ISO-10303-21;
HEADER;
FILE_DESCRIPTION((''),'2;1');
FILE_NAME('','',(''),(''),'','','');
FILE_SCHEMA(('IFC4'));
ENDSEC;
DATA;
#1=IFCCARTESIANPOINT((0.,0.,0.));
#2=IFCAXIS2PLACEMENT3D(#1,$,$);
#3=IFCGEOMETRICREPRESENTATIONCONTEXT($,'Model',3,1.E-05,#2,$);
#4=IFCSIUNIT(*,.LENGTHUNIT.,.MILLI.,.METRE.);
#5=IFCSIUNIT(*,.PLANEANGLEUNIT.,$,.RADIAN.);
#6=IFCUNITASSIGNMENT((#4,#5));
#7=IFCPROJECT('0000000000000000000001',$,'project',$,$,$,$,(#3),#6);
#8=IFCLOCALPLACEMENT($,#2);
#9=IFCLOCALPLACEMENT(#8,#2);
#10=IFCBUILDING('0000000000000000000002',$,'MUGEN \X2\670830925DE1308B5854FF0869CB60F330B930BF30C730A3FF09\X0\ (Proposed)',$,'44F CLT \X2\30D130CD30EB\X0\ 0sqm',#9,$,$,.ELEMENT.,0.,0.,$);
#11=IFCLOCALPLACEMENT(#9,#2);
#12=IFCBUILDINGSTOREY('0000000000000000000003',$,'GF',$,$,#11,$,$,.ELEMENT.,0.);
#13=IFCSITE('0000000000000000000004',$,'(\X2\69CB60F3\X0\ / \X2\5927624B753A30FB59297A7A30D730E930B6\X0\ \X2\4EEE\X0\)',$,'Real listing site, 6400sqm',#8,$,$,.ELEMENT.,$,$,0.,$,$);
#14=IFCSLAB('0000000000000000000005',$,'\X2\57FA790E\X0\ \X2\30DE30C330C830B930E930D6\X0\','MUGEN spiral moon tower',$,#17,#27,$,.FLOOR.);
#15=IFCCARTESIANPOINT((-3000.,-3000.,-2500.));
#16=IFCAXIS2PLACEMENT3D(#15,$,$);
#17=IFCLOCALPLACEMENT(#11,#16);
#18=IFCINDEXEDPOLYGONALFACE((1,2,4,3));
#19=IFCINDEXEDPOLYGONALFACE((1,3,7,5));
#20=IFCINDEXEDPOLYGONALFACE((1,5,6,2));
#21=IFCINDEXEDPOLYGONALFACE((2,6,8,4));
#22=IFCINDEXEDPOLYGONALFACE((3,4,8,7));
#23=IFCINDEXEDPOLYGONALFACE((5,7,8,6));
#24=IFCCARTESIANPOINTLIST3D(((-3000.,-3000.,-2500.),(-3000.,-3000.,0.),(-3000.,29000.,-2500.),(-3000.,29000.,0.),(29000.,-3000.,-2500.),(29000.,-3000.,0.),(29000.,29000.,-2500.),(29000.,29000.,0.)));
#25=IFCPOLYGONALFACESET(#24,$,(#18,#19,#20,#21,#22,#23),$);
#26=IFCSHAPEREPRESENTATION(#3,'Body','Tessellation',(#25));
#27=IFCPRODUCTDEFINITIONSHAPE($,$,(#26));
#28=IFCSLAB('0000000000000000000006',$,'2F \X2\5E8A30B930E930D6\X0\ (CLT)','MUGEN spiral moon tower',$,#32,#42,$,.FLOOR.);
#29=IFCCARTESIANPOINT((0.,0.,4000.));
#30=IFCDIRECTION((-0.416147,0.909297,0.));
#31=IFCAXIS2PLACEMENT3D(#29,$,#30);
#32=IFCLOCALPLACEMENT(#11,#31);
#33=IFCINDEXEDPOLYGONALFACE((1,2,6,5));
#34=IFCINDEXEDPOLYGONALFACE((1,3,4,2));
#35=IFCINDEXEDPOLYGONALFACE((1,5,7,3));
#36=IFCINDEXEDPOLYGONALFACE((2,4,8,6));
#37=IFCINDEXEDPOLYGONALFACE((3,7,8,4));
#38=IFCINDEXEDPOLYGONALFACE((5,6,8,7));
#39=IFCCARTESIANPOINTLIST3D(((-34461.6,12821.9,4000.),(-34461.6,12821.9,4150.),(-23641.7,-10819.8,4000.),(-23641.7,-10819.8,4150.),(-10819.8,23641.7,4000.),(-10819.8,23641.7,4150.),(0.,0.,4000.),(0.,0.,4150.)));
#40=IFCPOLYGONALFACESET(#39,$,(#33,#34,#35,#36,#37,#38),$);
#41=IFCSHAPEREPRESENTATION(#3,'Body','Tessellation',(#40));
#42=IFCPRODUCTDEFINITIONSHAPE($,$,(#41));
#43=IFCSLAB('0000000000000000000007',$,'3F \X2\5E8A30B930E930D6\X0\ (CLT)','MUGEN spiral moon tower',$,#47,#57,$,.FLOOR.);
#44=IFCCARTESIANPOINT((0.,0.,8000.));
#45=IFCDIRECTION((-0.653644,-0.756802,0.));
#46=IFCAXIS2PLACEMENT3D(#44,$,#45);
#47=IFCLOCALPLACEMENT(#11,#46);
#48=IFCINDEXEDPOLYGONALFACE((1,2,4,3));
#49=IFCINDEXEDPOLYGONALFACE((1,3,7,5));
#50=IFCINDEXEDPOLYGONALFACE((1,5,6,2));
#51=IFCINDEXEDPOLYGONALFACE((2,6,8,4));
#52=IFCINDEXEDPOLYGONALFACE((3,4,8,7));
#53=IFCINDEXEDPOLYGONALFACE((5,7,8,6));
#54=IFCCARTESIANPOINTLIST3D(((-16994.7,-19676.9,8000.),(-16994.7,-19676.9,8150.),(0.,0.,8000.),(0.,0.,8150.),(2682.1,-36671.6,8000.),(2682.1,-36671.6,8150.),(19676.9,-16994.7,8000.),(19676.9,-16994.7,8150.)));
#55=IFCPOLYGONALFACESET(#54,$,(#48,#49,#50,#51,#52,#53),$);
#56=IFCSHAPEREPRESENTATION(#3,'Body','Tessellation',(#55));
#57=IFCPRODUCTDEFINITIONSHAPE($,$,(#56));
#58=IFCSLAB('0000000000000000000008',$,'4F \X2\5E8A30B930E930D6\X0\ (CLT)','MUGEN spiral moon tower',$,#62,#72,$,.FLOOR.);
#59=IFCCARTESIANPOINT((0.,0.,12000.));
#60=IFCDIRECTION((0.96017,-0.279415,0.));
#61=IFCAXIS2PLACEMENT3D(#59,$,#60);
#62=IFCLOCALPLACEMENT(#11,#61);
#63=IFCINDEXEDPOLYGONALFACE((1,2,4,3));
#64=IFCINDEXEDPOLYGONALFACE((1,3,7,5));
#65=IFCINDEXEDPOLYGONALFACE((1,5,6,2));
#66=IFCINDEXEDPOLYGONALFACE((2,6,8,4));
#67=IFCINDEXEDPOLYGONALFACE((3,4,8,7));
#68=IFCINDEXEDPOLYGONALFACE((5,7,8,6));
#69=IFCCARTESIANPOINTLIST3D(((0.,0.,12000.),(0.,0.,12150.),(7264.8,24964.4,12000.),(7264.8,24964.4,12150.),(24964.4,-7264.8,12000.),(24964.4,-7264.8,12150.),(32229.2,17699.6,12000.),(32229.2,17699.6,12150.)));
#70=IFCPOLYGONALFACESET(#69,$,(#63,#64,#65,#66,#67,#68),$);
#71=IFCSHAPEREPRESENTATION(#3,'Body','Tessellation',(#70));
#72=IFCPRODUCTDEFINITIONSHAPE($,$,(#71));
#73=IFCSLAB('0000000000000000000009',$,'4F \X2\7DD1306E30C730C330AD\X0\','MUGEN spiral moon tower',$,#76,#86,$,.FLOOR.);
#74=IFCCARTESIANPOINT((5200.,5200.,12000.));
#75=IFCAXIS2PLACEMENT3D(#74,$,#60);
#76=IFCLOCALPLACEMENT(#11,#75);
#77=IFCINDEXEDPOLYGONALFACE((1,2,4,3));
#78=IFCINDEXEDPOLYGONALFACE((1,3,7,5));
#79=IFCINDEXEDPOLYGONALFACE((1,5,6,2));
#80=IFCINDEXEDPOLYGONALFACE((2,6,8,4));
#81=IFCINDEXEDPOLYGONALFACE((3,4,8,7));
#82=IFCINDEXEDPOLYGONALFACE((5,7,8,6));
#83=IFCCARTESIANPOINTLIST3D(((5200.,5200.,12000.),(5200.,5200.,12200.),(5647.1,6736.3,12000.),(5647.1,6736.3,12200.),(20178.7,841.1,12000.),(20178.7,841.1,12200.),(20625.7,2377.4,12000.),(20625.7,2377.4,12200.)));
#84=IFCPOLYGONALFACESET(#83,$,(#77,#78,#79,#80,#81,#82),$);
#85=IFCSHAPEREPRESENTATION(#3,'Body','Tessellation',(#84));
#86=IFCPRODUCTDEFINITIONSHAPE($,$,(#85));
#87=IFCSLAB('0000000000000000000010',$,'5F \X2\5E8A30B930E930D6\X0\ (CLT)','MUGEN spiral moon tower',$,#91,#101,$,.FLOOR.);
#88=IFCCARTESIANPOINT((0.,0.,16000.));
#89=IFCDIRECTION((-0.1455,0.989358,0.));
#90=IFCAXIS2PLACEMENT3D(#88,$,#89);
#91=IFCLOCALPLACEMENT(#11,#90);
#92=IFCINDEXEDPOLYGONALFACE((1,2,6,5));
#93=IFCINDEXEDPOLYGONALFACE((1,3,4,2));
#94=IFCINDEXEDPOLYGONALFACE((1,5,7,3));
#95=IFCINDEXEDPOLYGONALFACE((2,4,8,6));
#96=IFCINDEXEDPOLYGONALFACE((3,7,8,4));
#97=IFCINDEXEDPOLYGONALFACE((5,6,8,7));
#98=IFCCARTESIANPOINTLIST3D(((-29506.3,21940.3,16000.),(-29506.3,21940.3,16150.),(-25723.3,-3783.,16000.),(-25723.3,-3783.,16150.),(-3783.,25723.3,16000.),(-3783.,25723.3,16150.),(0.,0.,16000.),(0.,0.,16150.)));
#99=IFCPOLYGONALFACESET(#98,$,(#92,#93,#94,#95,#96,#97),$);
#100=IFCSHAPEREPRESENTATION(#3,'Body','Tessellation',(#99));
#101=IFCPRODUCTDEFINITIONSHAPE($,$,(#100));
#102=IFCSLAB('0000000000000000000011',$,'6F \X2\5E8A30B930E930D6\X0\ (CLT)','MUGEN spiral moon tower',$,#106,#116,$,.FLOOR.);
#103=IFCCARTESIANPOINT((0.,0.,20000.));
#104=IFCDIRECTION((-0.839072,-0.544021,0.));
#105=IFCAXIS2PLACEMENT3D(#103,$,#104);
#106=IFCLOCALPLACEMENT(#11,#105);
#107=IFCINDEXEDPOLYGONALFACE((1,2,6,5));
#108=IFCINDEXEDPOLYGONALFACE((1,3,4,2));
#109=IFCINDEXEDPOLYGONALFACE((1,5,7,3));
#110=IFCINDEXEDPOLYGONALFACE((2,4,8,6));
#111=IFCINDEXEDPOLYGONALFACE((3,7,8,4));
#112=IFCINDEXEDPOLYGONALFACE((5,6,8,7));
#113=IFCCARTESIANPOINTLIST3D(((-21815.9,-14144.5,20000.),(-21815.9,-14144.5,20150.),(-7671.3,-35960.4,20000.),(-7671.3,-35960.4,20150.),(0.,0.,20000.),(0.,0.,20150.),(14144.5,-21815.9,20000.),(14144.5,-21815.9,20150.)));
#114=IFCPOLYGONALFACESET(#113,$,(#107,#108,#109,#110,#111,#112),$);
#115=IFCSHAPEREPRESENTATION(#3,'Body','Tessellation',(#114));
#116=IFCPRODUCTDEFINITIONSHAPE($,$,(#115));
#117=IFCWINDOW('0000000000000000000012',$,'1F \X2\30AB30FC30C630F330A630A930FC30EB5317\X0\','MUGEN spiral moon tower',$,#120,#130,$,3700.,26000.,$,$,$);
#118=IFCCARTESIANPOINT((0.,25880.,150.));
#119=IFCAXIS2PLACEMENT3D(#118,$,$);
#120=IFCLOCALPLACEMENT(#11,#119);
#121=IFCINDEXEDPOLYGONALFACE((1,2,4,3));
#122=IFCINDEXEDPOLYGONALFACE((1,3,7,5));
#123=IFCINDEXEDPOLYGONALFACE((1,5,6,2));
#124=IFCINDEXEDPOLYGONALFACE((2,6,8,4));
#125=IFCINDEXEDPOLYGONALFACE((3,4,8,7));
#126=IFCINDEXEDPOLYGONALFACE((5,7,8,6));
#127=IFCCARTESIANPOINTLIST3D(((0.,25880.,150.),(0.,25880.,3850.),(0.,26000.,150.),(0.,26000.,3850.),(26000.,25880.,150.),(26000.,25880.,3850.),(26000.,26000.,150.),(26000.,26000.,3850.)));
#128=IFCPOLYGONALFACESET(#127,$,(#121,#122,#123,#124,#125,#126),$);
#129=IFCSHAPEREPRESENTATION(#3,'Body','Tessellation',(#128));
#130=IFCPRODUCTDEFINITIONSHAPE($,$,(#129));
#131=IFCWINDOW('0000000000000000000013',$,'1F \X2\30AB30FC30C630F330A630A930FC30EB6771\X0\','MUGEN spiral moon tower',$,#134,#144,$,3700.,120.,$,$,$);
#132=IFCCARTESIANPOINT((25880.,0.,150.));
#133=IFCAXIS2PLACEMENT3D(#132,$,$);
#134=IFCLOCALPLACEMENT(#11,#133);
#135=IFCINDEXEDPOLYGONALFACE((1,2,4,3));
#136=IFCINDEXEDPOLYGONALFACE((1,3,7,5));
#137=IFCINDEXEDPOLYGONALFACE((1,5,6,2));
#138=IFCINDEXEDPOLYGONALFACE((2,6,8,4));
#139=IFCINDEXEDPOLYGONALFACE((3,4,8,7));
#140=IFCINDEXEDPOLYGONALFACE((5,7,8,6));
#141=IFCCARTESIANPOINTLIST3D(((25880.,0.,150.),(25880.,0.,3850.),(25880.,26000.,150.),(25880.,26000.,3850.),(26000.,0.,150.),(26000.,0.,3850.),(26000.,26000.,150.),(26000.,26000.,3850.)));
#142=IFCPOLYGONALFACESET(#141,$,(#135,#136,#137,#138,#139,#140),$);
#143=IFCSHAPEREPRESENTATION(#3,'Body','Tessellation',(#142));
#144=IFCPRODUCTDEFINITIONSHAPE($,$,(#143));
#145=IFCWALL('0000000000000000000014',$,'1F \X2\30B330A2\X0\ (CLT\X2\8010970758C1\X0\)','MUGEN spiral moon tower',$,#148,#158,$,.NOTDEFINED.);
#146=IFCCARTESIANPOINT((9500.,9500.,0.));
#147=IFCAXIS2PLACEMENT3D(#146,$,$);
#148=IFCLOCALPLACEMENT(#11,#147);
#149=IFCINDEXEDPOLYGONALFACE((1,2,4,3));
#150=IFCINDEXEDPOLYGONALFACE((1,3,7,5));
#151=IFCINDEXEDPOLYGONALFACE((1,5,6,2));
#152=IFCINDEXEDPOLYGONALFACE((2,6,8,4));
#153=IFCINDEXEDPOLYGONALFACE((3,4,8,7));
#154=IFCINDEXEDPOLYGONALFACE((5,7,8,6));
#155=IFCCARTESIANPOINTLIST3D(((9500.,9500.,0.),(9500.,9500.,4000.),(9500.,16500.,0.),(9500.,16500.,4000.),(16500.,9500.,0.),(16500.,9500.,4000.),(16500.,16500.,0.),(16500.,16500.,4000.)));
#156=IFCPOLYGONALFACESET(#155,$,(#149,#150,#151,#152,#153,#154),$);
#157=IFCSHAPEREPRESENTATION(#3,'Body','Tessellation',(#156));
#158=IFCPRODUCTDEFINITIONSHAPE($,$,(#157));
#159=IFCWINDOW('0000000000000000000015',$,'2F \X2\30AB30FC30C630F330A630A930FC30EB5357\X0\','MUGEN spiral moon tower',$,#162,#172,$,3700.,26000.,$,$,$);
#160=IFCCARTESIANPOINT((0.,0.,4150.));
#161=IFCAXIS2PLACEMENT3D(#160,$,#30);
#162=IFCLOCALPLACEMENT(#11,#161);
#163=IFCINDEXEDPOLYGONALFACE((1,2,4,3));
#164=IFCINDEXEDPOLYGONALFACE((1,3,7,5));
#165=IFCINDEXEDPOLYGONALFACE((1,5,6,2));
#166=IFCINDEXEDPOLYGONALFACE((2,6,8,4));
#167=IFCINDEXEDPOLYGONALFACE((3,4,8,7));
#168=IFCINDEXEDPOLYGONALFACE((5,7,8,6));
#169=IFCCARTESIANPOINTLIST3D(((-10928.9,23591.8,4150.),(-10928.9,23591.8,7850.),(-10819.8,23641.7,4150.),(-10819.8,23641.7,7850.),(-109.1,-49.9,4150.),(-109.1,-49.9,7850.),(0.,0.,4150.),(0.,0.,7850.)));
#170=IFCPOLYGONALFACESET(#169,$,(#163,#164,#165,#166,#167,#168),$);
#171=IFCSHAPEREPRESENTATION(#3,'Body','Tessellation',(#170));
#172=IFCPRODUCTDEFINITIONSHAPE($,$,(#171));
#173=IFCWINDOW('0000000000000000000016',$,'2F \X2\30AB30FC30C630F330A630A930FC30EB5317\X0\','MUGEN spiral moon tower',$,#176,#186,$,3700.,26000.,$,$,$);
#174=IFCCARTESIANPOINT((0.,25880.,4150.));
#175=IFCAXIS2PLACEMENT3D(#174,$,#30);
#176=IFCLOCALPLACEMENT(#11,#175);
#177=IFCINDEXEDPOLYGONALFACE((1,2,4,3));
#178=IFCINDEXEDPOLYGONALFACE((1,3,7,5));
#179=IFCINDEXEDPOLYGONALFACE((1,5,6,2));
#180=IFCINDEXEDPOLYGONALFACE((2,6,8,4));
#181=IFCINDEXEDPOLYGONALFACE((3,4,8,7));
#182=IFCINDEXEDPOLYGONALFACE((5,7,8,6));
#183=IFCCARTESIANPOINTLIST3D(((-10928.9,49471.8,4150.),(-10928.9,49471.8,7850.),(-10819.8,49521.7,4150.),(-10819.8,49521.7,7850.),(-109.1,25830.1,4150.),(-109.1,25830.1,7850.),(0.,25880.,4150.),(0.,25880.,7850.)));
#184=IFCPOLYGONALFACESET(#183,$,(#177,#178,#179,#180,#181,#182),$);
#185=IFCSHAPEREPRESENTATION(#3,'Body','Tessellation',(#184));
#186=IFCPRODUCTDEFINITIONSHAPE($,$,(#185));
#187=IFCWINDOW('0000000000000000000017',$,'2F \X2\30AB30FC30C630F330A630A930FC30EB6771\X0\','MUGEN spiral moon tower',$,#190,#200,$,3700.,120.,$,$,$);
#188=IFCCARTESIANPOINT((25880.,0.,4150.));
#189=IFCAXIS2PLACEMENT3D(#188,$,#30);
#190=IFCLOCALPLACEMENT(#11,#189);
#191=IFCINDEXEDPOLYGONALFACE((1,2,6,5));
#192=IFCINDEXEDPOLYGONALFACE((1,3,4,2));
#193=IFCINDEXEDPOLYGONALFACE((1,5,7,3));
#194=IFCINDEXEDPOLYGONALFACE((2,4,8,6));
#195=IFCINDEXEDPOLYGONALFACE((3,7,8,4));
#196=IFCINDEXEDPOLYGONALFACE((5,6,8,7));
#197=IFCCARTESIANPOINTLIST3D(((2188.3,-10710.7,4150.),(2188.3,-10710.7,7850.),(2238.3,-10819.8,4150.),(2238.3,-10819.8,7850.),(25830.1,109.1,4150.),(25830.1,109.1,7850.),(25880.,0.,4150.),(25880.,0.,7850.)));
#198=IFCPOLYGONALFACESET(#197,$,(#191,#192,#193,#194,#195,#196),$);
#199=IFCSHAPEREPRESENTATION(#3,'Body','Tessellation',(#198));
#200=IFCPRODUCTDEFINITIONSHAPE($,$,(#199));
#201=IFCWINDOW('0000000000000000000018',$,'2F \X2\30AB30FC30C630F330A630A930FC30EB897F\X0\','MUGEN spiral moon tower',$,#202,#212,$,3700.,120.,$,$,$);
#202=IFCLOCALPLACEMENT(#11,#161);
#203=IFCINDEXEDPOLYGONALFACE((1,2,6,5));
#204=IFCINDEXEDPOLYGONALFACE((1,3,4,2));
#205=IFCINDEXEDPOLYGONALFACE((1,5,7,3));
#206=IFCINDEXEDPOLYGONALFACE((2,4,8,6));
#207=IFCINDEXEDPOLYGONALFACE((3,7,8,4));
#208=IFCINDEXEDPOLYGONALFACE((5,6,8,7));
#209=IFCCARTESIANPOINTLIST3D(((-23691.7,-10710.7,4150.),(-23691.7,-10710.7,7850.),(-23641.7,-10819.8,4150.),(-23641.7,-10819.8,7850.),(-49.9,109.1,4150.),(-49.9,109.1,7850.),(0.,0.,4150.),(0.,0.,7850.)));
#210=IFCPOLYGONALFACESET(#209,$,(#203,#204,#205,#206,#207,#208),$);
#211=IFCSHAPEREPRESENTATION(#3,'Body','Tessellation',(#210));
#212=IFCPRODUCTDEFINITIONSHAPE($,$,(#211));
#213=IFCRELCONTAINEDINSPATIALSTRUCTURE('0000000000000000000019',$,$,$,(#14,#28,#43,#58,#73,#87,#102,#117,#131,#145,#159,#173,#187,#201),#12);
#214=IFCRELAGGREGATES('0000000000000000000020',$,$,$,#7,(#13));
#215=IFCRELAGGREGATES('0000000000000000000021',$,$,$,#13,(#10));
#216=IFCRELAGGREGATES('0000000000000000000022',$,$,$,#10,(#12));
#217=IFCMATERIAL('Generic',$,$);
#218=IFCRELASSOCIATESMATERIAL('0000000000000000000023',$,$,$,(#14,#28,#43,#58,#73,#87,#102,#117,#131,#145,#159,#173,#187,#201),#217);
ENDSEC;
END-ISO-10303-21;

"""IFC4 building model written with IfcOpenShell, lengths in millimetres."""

from ifc_helpers import new_model, si_unit, frame, frame_2d, origin, place, context, project, spatial, rectangle, extrude, material, element, save


model = new_model("IFC4")

# Units and contexts
model_context = context("Model", 3, precision=1e-05, world=origin())
ifc_project = project(units=[si_unit("LENGTHUNIT", "METRE", prefix="MILLI"), si_unit("PLANEANGLEUNIT", "RADIAN")], contexts=[model_context])

# Site, building, storey
site_placement = place(None, origin())
site = spatial("IfcSite", under=ifc_project, at=site_placement, Name="(構想 / 大手町・天空プラザ 仮)", ObjectType="Real listing site, 6400sqm", CompositionType="ELEMENT", RefElevation=0.0)
building_placement = place(site_placement, origin())
building = spatial("IfcBuilding", under=site, at=building_placement, Name="MUGEN 月を巡る塔（構想スタディ） (Proposed)", ObjectType="44F CLT パネル 0sqm", CompositionType="ELEMENT", ElevationOfRefHeight=0.0, ElevationOfTerrain=0.0)
storey_placement = place(building_placement, origin())
storey = spatial("IfcBuildingStorey", under=building, at=storey_placement, Name="GF", CompositionType="ELEMENT", Elevation=0.0)

# Slabs
ifc_material = material(Name="Generic")
slab_1_placement = place(storey_placement, frame((-3000.0, -3000.0, -2500.0)))
element("IfcSlab", 1, at=slab_1_placement, inside=storey, material=ifc_material, Name="基礎 マットスラブ", Description="MUGEN spiral moon tower", PredefinedType="FLOOR", context=model_context, shape_type="SweptSolid", body=[
    extrude(rectangle(XDim=32000.0, YDim=32000.0, at=frame_2d((16000.0, 16000.0))), frame((-3000.0, -3000.0, -2500.0)), (0.0, 0.0, 1.0), 2500.0),
])
slab_2_placement = place(storey_placement, frame((0.0, 0.0, 4000.0), x_axis=(-0.416147, 0.909297, 0.0)))
element("IfcSlab", 2, at=slab_2_placement, inside=storey, material=ifc_material, Name="2F 床スラブ (CLT)", Description="MUGEN spiral moon tower", PredefinedType="FLOOR", context=model_context, shape_type="SweptSolid", body=[
    extrude(rectangle(XDim=26000.0, YDim=26000.0, at=frame_2d((13000.0, 13000.0))), frame((0.0, 0.0, 4000.0), x_axis=(-0.416147, 0.909297, 0.0)), (0.0, 0.0, 1.0), 150.0),
])
slab_3_placement = place(storey_placement, frame((0.0, 0.0, 8000.0), x_axis=(-0.653644, -0.756802, 0.0)))
element("IfcSlab", 3, at=slab_3_placement, inside=storey, material=ifc_material, Name="3F 床スラブ (CLT)", Description="MUGEN spiral moon tower", PredefinedType="FLOOR", context=model_context, shape_type="SweptSolid", body=[
    extrude(rectangle(XDim=26000.0, YDim=26000.0, at=frame_2d((13000.0, 13000.0))), frame((0.0, 0.0, 8000.0), x_axis=(-0.653644, -0.756802, 0.0)), (0.0, 0.0, 1.0), 150.0),
])
slab_4_placement = place(storey_placement, frame((0.0, 0.0, 12000.0), x_axis=(0.96017, -0.279415, 0.0)))
element("IfcSlab", 4, at=slab_4_placement, inside=storey, material=ifc_material, Name="4F 床スラブ (CLT)", Description="MUGEN spiral moon tower", PredefinedType="FLOOR", context=model_context, shape_type="SweptSolid", body=[
    extrude(rectangle(XDim=26000.0, YDim=26000.0, at=frame_2d((13000.0, 13000.0))), frame((0.0, 0.0, 12000.0), x_axis=(0.96017, -0.279415, 0.0)), (0.0, 0.0, 1.0), 150.0),
])
slab_5_placement = place(storey_placement, frame((5200.0, 5200.0, 12000.0), x_axis=(0.96017, -0.279415, 0.0)))
element("IfcSlab", 5, at=slab_5_placement, inside=storey, material=ifc_material, Name="4F 緑のデッキ", Description="MUGEN spiral moon tower", PredefinedType="FLOOR", context=model_context, shape_type="SweptSolid", body=[
    extrude(rectangle(XDim=15600.0, YDim=1600.0, at=frame_2d((7800.0, 800.0))), frame((5200.0, 5200.0, 12000.0), x_axis=(0.96017, -0.279415, 0.0)), (0.0, 0.0, 1.0), 200.0),
])
slab_6_placement = place(storey_placement, frame((0.0, 0.0, 16000.0), x_axis=(-0.1455, 0.989358, 0.0)))
element("IfcSlab", 6, at=slab_6_placement, inside=storey, material=ifc_material, Name="5F 床スラブ (CLT)", Description="MUGEN spiral moon tower", PredefinedType="FLOOR", context=model_context, shape_type="SweptSolid", body=[
    extrude(rectangle(XDim=26000.0, YDim=26000.0, at=frame_2d((13000.0, 13000.0))), frame((0.0, 0.0, 16000.0), x_axis=(-0.1455, 0.989358, 0.0)), (0.0, 0.0, 1.0), 150.0),
])
slab_7_placement = place(storey_placement, frame((0.0, 0.0, 20000.0), x_axis=(-0.839072, -0.544021, 0.0)))
element("IfcSlab", 7, at=slab_7_placement, inside=storey, material=ifc_material, Name="6F 床スラブ (CLT)", Description="MUGEN spiral moon tower", PredefinedType="FLOOR", context=model_context, shape_type="SweptSolid", body=[
    extrude(rectangle(XDim=26000.0, YDim=26000.0, at=frame_2d((13000.0, 13000.0))), frame((0.0, 0.0, 20000.0), x_axis=(-0.839072, -0.544021, 0.0)), (0.0, 0.0, 1.0), 150.0),
])

# Windows
window_1_placement = place(storey_placement, frame((0.0, 25880.0, 150.0)))
element("IfcWindow", 8, at=window_1_placement, inside=storey, material=ifc_material, Name="1F カーテンウォール北", Description="MUGEN spiral moon tower", OverallHeight=3700.0, OverallWidth=26000.0, context=model_context, shape_type="SweptSolid", body=[
    extrude(rectangle(XDim=26000.0, YDim=120.0, at=frame_2d((13000.0, 60.0))), frame((0.0, 25880.0, 150.0)), (0.0, 0.0, 1.0), 3700.0),
])
window_2_placement = place(storey_placement, frame((25880.0, 0.0, 150.0)))
element("IfcWindow", 9, at=window_2_placement, inside=storey, material=ifc_material, Name="1F カーテンウォール東", Description="MUGEN spiral moon tower", OverallHeight=3700.0, OverallWidth=120.0, context=model_context, shape_type="SweptSolid", body=[
    extrude(rectangle(XDim=120.0, YDim=26000.0, at=frame_2d((60.0, 13000.0))), frame((25880.0, 0.0, 150.0)), (0.0, 0.0, 1.0), 3700.0),
])

# Wall
wall_1_placement = place(storey_placement, frame((9500.0, 9500.0, 0.0)))
element("IfcWall", 10, at=wall_1_placement, inside=storey, material=ifc_material, Name="1F コア (CLT耐震壁)", Description="MUGEN spiral moon tower", PredefinedType="NOTDEFINED", context=model_context, shape_type="SweptSolid", body=[
    extrude(rectangle(XDim=7000.0, YDim=7000.0, at=frame_2d((3500.0, 3500.0))), frame((9500.0, 9500.0, 0.0)), (0.0, 0.0, 1.0), 4000.0),
])

# Windows
window_3_placement = place(storey_placement, frame((0.0, 0.0, 4150.0), x_axis=(-0.416147, 0.909297, 0.0)))
element("IfcWindow", 11, at=window_3_placement, inside=storey, material=ifc_material, Name="2F カーテンウォール南", Description="MUGEN spiral moon tower", OverallHeight=3700.0, OverallWidth=26000.0, context=model_context, shape_type="SweptSolid", body=[
    extrude(rectangle(XDim=26000.0, YDim=120.0, at=frame_2d((13000.0, 60.0))), frame((0.0, 0.0, 4150.0), x_axis=(-0.416147, 0.909297, 0.0)), (0.0, 0.0, 1.0), 3700.0),
])
window_4_placement = place(storey_placement, frame((0.0, 25880.0, 4150.0), x_axis=(-0.416147, 0.909297, 0.0)))
element("IfcWindow", 12, at=window_4_placement, inside=storey, material=ifc_material, Name="2F カーテンウォール北", Description="MUGEN spiral moon tower", OverallHeight=3700.0, OverallWidth=26000.0, context=model_context, shape_type="SweptSolid", body=[
    extrude(rectangle(XDim=26000.0, YDim=120.0, at=frame_2d((13000.0, 60.0))), frame((0.0, 25880.0, 4150.0), x_axis=(-0.416147, 0.909297, 0.0)), (0.0, 0.0, 1.0), 3700.0),
])
window_5_placement = place(storey_placement, frame((25880.0, 0.0, 4150.0), x_axis=(-0.416147, 0.909297, 0.0)))
element("IfcWindow", 13, at=window_5_placement, inside=storey, material=ifc_material, Name="2F カーテンウォール東", Description="MUGEN spiral moon tower", OverallHeight=3700.0, OverallWidth=120.0, context=model_context, shape_type="SweptSolid", body=[
    extrude(rectangle(XDim=120.0, YDim=26000.0, at=frame_2d((60.0, 13000.0))), frame((25880.0, 0.0, 4150.0), x_axis=(-0.416147, 0.909297, 0.0)), (0.0, 0.0, 1.0), 3700.0),
])
window_6_placement = place(storey_placement, frame((0.0, 0.0, 4150.0), x_axis=(-0.416147, 0.909297, 0.0)))
element("IfcWindow", 14, at=window_6_placement, inside=storey, material=ifc_material, Name="2F カーテンウォール西", Description="MUGEN spiral moon tower", OverallHeight=3700.0, OverallWidth=120.0, context=model_context, shape_type="SweptSolid", body=[
    extrude(rectangle(XDim=120.0, YDim=26000.0, at=frame_2d((60.0, 13000.0))), frame((0.0, 0.0, 4150.0), x_axis=(-0.416147, 0.909297, 0.0)), (0.0, 0.0, 1.0), 3700.0),
])

save(model, "model.ifc")
